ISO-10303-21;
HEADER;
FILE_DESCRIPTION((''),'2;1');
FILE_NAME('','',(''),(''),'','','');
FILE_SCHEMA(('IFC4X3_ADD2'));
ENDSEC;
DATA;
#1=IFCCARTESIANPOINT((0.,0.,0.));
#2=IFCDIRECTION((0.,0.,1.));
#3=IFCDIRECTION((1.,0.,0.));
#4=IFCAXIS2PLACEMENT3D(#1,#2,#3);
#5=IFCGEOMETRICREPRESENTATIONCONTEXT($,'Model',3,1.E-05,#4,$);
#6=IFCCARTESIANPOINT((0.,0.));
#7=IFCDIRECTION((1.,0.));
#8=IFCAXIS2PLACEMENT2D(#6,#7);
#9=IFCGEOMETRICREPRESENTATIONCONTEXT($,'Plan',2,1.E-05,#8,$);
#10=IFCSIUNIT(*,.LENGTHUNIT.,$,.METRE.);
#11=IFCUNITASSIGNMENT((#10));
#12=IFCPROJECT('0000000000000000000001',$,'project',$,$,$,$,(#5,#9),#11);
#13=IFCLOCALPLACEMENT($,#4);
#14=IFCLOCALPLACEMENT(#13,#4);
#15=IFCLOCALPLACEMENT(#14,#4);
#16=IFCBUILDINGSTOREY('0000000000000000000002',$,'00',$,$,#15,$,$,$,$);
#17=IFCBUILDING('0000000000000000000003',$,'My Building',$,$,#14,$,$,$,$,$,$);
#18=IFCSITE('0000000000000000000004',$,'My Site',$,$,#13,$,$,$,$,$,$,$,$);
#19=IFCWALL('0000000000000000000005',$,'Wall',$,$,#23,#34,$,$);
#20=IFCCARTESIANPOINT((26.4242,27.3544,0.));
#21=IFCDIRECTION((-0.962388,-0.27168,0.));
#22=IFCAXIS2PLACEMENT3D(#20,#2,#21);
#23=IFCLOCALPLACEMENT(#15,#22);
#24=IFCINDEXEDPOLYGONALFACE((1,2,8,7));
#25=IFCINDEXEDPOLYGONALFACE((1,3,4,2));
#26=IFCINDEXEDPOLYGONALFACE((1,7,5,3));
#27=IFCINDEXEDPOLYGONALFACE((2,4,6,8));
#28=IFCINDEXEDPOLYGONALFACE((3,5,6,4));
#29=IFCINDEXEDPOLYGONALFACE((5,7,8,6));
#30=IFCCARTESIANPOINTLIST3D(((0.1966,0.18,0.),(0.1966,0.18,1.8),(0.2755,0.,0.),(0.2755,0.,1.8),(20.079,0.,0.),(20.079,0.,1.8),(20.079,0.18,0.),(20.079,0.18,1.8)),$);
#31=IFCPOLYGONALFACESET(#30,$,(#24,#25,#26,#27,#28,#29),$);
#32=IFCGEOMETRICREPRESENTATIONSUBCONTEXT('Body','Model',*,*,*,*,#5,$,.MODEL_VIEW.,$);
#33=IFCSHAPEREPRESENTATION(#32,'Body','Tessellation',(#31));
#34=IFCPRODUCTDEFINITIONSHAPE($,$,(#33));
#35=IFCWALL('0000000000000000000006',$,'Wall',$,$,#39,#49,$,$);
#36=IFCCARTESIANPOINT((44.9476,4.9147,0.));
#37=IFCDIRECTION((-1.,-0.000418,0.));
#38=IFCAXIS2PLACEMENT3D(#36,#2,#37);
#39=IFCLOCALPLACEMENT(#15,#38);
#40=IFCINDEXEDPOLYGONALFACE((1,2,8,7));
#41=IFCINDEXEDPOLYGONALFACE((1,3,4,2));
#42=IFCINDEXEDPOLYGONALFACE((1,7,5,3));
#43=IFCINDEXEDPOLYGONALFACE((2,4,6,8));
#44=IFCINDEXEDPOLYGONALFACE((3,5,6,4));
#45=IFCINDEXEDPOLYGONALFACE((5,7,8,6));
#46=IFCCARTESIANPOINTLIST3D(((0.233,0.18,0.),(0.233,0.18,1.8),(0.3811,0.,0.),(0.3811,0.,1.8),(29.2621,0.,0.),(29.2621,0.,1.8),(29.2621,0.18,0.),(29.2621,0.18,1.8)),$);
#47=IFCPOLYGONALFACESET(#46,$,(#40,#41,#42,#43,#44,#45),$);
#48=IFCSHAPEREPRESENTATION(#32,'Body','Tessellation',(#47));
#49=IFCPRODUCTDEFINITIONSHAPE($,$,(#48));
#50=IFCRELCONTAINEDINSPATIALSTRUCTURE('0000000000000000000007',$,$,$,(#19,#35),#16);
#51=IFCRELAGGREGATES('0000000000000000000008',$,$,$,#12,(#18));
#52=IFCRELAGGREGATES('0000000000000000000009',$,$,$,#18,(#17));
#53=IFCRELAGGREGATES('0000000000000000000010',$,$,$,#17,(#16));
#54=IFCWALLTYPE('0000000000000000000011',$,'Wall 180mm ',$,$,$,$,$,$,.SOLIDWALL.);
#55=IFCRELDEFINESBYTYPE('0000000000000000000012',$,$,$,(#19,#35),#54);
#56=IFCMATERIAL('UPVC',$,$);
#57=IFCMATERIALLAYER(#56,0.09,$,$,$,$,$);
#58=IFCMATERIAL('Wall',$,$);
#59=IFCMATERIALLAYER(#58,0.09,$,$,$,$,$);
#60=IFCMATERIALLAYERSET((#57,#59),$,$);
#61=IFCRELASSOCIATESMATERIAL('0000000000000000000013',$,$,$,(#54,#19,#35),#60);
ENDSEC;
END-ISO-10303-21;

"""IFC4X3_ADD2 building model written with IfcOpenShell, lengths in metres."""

from ifc_helpers import new_model, si_unit, frame, origin_with_axes, origin_2d_with_axis, place, context, subcontext, project, spatial, indexed_curve, outline, extrude, clip, halfspace, material, layer, layer_set, layer_usage, type_object, element, save


model = new_model("IFC4X3_ADD2")

# Units and contexts
model_context = context("Model", 3, precision=1e-05, world=origin_with_axes())
plan_context = context("Plan", 2, precision=1e-05, world=origin_2d_with_axis())
body_context = subcontext(model_context, "Body", "Model", "MODEL_VIEW")
ifc_project = project(units=[si_unit("LENGTHUNIT", "METRE")], contexts=[model_context, plan_context])

# Site, building, storey
site_placement = place(None, origin_with_axes())
site = spatial("IfcSite", under=ifc_project, at=site_placement, Name="My Site")
building_placement = place(site_placement, origin_with_axes())
building = spatial("IfcBuilding", under=site, at=building_placement, Name="My Building")
storey_placement = place(building_placement, origin_with_axes())
storey = spatial("IfcBuildingStorey", under=building, at=storey_placement, Name="00")

# Shared definitions
ifc_material_1 = material(Name="UPVC")

# Walls
ifc_material_2 = material(Name="Wall")
ifc_layer_1 = layer(ifc_material_1, 0.09)
ifc_layer_2 = layer(ifc_material_2, 0.09)
ifc_layer_set_1 = layer_set([ifc_layer_1, ifc_layer_2])
ifc_layer_usage_1 = layer_usage(ifc_layer_set_1, "AXIS2", "POSITIVE", 0.0)
wall_type_1 = type_object("IfcWallType", Name="Wall 180mm ", PredefinedType="SOLIDWALL", material=ifc_layer_set_1)
wall_1_placement = place(storey_placement, frame((26.4242, 27.3544, 0.0), z_axis=(0.0, 0.0, 1.0), x_axis=(-0.962388, -0.27168, 0.0)))
element("IfcWall", 1, at=wall_1_placement, inside=storey, type_object=wall_type_1, material=ifc_layer_usage_1, Name="Wall", context=body_context, shape_type="Clipping", body=[
    clip(extrude(outline(indexed_curve([(0.0, 0.0), (0.0, 0.18), (20.079, 0.18), (20.079, 0.0), (0.0, 0.0)], self_intersect=False)), origin_with_axes(), (0.0, 0.0, 1.0), 1.8), halfspace(frame((0.2755, 0.0, 0.0), z_axis=(-0.323993, -0.14217, 0.0), x_axis=(-0.401823, 0.915717, 0.0)), False)),
])
ifc_layer_usage_2 = layer_usage(ifc_layer_set_1, "AXIS2", "POSITIVE", 0.0)
wall_2_placement = place(storey_placement, frame((44.9476, 4.9147, 0.0), z_axis=(0.0, 0.0, 1.0), x_axis=(-1.0, -0.000418, 0.0)))
element("IfcWall", 2, at=wall_2_placement, inside=storey, type_object=wall_type_1, material=ifc_layer_usage_2, Name="Wall", context=body_context, shape_type="Clipping", body=[
    clip(extrude(outline(indexed_curve([(0.0, 0.0), (0.0, 0.18), (29.2621, 0.18), (29.2621, 0.0), (0.0, 0.0)], self_intersect=False)), origin_with_axes(), (0.0, 0.0, 1.0), 1.8), halfspace(frame((0.3811, 0.0, 0.0), z_axis=(-0.539999, -0.44408, 0.0), x_axis=(-0.635174, 0.772369, 0.0)), False)),
])

save(model, "model.ifc")
